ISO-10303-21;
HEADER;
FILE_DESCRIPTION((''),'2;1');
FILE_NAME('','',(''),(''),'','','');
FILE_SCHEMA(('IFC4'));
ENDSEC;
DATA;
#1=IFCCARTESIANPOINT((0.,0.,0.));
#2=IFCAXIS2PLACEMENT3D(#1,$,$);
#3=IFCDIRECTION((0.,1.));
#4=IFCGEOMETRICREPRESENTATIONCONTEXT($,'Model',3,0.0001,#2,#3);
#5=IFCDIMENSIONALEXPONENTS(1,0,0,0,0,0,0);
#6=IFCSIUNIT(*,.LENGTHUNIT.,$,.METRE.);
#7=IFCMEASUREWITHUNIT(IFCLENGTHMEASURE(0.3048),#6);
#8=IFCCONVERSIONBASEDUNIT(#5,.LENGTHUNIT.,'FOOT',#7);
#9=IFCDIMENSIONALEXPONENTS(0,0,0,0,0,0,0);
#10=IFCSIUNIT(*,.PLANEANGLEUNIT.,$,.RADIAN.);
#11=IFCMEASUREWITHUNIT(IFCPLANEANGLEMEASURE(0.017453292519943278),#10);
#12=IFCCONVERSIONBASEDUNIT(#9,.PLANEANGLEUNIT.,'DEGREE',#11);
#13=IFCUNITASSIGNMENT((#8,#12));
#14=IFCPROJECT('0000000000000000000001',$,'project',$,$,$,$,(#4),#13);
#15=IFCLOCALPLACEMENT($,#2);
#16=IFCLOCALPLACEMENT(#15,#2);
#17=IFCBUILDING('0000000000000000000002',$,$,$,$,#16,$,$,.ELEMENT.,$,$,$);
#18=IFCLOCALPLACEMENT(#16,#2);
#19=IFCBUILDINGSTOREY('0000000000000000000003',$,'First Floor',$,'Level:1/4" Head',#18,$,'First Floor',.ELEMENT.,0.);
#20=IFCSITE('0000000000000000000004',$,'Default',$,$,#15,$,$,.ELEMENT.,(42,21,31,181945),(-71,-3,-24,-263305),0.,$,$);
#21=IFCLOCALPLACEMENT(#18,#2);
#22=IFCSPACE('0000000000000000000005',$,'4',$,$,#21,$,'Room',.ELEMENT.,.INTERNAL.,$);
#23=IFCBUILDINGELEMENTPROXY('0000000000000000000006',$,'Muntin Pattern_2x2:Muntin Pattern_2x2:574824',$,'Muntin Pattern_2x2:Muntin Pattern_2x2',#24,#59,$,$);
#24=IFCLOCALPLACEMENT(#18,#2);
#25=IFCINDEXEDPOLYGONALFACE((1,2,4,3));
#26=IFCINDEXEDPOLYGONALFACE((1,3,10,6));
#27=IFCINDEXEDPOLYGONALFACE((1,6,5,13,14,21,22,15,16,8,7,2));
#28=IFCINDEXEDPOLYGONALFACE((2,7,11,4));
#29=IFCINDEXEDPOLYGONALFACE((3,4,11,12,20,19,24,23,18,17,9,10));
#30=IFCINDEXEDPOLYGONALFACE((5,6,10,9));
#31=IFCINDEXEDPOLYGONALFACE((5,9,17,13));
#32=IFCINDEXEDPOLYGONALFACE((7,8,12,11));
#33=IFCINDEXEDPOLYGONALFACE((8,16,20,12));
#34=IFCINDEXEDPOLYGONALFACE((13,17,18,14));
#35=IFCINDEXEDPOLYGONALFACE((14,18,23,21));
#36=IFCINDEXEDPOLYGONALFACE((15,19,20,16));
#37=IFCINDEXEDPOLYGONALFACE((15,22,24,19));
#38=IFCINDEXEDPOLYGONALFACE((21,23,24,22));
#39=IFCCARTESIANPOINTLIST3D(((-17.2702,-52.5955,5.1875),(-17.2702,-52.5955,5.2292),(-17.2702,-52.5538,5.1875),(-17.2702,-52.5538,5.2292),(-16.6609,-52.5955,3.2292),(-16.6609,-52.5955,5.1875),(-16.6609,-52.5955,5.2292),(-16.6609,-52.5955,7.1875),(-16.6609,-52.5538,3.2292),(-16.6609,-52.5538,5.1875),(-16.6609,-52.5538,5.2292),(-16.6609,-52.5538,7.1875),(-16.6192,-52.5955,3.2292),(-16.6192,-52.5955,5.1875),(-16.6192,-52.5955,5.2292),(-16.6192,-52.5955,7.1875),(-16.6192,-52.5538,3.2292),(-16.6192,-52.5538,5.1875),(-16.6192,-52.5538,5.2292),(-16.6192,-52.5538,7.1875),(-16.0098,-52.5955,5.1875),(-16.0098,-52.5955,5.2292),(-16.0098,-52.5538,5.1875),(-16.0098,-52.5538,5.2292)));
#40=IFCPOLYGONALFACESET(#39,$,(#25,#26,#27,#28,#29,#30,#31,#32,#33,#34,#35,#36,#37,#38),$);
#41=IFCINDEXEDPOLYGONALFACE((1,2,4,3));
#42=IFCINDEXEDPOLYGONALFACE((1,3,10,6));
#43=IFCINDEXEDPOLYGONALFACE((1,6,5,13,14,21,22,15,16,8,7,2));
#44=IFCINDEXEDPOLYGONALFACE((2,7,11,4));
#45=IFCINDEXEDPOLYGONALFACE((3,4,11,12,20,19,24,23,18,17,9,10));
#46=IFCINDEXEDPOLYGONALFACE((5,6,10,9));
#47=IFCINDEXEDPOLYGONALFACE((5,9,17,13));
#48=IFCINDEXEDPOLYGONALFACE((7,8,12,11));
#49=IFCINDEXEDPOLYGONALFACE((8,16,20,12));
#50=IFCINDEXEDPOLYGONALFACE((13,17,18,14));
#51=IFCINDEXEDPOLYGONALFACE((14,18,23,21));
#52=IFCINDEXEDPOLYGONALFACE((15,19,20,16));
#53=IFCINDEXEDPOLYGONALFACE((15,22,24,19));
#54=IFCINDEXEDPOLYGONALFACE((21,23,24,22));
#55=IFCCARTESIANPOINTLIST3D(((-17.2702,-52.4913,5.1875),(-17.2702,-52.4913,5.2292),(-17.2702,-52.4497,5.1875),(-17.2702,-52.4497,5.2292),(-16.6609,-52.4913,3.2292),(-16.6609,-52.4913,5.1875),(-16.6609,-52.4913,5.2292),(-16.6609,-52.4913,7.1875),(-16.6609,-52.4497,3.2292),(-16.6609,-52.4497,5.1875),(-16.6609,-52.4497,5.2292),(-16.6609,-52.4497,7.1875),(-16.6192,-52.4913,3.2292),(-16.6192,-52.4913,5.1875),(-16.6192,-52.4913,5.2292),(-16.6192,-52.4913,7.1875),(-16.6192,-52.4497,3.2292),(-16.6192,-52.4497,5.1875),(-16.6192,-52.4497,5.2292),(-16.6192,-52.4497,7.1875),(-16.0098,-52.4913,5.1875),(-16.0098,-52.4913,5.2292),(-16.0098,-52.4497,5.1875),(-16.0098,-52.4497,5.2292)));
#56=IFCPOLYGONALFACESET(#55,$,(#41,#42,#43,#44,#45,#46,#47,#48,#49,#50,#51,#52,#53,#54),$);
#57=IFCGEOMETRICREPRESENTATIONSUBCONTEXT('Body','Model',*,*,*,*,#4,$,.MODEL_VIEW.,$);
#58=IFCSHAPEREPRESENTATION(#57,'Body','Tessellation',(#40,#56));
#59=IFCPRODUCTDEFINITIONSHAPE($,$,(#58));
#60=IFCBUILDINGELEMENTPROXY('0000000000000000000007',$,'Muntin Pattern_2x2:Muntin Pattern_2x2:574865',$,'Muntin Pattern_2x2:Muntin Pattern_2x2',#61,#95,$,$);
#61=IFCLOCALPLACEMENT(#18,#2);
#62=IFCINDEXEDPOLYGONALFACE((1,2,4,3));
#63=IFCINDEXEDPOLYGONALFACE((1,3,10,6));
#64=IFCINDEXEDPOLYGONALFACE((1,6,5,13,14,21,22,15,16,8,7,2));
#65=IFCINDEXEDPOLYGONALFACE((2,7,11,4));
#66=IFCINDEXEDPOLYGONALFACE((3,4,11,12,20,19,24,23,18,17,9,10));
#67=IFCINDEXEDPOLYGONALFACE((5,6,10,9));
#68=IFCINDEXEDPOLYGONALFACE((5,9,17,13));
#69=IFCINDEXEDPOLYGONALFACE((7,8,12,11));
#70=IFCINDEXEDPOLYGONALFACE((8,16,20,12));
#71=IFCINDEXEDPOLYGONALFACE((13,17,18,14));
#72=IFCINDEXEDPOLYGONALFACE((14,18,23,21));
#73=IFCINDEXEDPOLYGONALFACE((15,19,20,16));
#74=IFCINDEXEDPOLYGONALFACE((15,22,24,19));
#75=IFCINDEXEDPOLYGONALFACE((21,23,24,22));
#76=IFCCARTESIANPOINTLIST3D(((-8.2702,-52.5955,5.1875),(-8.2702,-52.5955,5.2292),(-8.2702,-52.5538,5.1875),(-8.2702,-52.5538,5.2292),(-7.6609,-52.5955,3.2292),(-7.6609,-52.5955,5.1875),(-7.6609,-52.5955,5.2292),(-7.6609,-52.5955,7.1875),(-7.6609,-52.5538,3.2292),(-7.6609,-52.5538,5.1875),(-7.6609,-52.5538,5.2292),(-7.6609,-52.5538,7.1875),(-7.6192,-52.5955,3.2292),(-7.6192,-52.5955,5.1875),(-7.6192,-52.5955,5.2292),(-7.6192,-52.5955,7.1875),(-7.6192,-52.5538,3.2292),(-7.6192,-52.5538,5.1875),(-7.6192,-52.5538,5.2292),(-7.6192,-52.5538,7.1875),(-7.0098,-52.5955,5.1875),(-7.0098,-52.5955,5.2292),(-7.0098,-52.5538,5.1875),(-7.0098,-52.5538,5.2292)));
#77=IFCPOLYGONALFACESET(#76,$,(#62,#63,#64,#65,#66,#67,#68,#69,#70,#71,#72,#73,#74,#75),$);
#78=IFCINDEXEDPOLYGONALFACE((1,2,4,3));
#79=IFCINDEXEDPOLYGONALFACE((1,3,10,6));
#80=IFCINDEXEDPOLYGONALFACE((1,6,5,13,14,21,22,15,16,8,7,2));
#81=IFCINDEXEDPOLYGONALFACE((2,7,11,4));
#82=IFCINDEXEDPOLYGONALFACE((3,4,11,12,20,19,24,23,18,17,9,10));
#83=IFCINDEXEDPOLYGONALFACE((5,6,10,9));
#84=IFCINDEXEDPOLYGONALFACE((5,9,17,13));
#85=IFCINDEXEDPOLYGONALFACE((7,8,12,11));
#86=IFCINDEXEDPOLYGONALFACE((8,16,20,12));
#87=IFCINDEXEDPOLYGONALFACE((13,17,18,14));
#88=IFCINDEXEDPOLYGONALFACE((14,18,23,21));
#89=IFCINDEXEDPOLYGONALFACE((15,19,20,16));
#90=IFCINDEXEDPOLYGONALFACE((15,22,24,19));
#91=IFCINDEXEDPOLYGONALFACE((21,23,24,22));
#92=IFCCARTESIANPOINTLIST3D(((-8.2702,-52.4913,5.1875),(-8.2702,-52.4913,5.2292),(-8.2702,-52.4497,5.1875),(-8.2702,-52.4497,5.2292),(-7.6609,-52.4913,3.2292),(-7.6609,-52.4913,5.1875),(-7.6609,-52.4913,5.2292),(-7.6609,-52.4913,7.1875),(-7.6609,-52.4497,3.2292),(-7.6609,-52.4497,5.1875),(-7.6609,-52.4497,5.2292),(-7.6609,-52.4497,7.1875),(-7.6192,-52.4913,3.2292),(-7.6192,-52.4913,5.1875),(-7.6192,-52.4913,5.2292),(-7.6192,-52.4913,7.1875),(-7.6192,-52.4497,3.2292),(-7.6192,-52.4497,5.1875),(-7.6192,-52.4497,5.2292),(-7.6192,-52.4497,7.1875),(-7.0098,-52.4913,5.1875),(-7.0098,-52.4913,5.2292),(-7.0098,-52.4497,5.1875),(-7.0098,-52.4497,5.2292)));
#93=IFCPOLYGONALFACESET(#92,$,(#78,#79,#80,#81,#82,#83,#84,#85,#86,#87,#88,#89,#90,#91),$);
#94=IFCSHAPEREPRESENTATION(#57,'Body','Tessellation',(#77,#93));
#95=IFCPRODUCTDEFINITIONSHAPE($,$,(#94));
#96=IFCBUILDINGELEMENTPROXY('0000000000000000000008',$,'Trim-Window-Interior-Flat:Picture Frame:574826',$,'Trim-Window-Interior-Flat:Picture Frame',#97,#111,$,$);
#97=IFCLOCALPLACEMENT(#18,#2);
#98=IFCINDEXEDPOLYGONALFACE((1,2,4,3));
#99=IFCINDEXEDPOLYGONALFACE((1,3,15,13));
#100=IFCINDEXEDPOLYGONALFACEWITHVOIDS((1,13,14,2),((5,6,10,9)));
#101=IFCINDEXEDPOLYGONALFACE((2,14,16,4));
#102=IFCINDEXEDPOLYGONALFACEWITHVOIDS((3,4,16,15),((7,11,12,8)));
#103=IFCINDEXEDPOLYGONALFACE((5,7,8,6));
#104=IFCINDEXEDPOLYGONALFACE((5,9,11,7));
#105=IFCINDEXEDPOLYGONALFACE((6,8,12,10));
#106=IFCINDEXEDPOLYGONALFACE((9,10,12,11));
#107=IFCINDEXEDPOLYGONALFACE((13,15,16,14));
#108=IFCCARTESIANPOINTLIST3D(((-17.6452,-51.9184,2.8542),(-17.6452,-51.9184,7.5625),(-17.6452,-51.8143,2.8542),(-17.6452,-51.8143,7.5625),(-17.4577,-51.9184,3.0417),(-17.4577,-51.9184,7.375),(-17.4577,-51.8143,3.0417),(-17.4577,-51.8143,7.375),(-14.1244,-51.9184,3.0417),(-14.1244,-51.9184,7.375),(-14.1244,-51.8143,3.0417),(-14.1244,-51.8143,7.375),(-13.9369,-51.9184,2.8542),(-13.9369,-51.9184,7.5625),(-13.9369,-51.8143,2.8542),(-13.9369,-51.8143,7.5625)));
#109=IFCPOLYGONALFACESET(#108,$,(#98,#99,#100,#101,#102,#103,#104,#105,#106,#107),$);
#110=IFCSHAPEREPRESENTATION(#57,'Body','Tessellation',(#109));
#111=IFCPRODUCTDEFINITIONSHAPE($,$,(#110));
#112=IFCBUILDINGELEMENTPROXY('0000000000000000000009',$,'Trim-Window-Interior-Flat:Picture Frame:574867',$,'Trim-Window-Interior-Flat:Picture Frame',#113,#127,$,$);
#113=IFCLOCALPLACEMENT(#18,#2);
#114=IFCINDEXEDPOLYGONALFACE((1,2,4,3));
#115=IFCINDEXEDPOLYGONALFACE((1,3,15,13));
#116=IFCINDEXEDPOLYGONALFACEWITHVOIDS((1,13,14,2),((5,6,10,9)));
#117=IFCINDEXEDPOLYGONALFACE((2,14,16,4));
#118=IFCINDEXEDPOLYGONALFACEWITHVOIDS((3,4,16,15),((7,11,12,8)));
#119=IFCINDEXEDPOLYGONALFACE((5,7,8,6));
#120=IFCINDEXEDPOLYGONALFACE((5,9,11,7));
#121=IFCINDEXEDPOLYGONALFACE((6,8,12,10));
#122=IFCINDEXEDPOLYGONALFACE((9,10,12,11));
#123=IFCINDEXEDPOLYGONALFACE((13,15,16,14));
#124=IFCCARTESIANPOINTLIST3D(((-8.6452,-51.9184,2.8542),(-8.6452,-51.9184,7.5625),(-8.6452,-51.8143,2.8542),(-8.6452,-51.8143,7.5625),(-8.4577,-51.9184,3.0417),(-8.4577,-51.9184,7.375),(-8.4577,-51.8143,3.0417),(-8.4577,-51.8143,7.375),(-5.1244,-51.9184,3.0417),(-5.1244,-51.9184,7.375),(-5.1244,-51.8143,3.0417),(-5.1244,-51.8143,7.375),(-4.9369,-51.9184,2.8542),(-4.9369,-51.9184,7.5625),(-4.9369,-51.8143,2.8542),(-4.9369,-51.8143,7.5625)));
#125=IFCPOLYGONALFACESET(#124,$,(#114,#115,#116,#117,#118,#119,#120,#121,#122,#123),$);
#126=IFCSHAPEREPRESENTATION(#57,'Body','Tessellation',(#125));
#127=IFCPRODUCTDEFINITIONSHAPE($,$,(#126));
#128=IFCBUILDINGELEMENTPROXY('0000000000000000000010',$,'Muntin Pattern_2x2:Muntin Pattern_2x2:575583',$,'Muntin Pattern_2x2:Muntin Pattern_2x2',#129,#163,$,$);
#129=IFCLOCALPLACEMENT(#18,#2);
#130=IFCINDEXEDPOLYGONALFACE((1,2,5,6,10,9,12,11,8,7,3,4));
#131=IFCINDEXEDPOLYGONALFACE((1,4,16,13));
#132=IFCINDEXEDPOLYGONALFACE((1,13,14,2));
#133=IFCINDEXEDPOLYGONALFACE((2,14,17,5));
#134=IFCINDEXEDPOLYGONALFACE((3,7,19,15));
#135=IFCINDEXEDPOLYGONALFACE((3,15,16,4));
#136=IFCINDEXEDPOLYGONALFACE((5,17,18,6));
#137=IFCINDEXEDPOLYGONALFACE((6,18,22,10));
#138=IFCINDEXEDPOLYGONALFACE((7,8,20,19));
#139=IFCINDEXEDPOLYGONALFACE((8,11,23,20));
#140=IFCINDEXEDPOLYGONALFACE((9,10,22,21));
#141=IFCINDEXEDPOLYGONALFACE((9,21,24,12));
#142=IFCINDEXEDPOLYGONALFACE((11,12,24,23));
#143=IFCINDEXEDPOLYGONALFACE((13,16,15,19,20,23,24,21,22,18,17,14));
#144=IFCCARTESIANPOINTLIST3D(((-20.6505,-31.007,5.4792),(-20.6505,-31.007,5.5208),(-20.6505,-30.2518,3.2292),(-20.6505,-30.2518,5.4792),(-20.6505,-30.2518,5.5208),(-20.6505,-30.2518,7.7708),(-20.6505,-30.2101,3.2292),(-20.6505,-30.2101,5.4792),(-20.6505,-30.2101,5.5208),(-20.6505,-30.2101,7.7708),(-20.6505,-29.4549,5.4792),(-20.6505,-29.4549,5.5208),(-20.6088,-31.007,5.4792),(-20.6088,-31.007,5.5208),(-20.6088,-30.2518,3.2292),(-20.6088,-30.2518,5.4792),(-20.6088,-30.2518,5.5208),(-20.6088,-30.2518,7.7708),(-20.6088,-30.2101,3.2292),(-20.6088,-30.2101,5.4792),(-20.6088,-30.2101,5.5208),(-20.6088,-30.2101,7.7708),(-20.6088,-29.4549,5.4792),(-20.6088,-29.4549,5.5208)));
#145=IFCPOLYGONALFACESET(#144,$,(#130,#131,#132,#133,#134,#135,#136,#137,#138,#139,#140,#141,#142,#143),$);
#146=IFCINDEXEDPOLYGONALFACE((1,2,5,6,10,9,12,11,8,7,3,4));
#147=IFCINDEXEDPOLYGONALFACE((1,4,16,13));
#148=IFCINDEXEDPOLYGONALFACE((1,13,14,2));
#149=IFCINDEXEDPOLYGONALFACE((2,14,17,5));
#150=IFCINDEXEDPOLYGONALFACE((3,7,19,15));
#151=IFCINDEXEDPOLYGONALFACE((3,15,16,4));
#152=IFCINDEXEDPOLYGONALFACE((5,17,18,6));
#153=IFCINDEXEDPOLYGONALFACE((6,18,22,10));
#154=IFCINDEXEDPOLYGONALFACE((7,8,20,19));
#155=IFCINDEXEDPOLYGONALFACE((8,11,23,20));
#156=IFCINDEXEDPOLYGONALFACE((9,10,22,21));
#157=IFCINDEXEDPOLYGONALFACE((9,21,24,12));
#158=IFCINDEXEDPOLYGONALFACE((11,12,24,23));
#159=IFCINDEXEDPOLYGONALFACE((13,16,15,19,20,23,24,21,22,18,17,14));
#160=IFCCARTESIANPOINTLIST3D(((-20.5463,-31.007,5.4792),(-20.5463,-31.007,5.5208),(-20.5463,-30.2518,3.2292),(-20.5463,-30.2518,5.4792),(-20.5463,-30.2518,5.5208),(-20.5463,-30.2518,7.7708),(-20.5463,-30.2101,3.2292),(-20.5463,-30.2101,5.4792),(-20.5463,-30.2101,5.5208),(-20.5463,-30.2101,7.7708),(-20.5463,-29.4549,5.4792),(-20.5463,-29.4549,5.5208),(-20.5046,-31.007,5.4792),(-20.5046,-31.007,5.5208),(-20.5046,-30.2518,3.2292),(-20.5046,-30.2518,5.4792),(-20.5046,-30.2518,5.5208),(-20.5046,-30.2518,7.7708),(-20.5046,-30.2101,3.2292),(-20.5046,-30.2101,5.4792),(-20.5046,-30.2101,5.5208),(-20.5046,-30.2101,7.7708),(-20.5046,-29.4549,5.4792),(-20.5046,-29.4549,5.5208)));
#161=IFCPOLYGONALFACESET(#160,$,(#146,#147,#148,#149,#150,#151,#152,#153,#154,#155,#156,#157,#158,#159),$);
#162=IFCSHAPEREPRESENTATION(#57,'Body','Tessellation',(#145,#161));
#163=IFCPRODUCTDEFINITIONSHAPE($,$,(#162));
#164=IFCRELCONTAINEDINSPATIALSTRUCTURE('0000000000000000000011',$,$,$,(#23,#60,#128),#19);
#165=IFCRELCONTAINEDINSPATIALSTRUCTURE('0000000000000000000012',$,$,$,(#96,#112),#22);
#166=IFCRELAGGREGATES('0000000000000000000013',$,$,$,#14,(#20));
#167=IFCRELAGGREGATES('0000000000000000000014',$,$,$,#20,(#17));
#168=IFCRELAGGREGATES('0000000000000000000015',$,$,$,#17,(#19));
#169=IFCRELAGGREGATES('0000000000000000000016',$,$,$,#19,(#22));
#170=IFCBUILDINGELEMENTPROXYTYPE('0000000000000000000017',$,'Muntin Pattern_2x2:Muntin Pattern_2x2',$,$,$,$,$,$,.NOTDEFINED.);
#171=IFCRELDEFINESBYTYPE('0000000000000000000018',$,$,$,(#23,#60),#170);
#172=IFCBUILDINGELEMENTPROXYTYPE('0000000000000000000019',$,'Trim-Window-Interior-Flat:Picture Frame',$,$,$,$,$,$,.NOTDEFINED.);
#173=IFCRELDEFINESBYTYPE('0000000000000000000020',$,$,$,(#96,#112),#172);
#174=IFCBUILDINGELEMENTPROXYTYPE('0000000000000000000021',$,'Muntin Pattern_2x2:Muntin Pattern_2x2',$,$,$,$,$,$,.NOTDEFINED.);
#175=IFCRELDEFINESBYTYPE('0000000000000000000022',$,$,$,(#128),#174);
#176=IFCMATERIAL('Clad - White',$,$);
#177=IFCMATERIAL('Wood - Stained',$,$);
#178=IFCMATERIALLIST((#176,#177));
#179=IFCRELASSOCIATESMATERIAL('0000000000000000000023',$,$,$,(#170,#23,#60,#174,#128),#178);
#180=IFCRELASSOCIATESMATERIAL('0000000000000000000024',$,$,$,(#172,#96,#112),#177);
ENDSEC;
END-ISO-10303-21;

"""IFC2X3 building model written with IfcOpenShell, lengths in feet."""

from ifc_helpers import new_model, entity, si_unit, converted_unit, direction, frame, origin, place, context, subcontext, project, spatial, polyline, outline, extrude, source, transform, mapped, material, material_list, type_object, type_shapes, element, save


model = new_model("IFC2X3")

# Units and contexts
model_context = context("Model", 3, precision=0.0001, world=origin(), true_north=direction((0.0, 1.0)))
body_context = subcontext(model_context, "Body", "Model", "MODEL_VIEW")
ifc_project = project(units=[converted_unit("LENGTHUNIT", "FOOT", entity("IfcLengthMeasure", 0.3048), si_unit("LENGTHUNIT", "METRE"), dimensions=[1, 0, 0, 0, 0, 0, 0]), converted_unit("PLANEANGLEUNIT", "DEGREE", entity("IfcPlaneAngleMeasure", 0.017453292519943278), si_unit("PLANEANGLEUNIT", "RADIAN"), dimensions=[0, 0, 0, 0, 0, 0, 0])], contexts=[model_context])

# Site, building, storey
site_placement = place(None, origin())
site = spatial("IfcSite", under=ifc_project, at=site_placement, Name="Default", CompositionType="ELEMENT", RefLatitude=(42, 21, 31, 181945), RefLongitude=(-71, -3, -24, -263305), RefElevation=0.0)
building_placement = place(site_placement, origin())
building = spatial("IfcBuilding", under=site, at=building_placement, CompositionType="ELEMENT")
storey_placement = place(building_placement, origin())
storey = spatial("IfcBuildingStorey", under=building, at=storey_placement, Name="First Floor", ObjectType="Level:1/4\" Head", LongName="First Floor", CompositionType="ELEMENT", Elevation=0.0)

# Shared definitions
space_1_placement = place(storey_placement, origin())
space_1 = spatial("IfcSpace", under=storey, at=space_1_placement, Name="4", LongName="Room", CompositionType="ELEMENT", InteriorOrExteriorSpace="INTERNAL")

# Building element proxies
ifc_material_1 = material(Name="Clad - White")
ifc_material_2 = material(Name="Wood - Stained")
ifc_material_list_1 = material_list([ifc_material_1, ifc_material_2])
building_element_proxy_type_1 = type_object("IfcBuildingElementProxyType", Name="Muntin Pattern_2x2:Muntin Pattern_2x2", PredefinedType="NOTDEFINED", material=ifc_material_list_1)
shared_shape_1 = source(origin(), body_context, "Body", "SweptSolid", [
    extrude(outline(polyline([(0.0208, -0.0208), (1.9792, -0.0208), (1.9792, 0.0208), (0.0208, 0.0208), (0.0208, 0.6302), (-0.0208, 0.6302), (-0.0208, 0.0208), (-1.9792, 0.0208), (-1.9792, -0.0208), (-0.0208, -0.0208), (-0.0208, -0.6302), (0.0208, -0.6302), (0.0208, -0.0208)])), frame((0.0, -0.0729, 1.9792), z_axis=(0.0, 1.0, 0.0), x_axis=(0.0, 0.0, 1.0)), (0.0, 0.0, 1.0), 0.0417),
    extrude(outline(polyline([(0.0208, -0.0208), (1.9792, -0.0208), (1.9792, 0.0208), (0.0208, 0.0208), (0.0208, 0.6302), (-0.0208, 0.6302), (-0.0208, 0.0208), (-1.9792, 0.0208), (-1.9792, -0.0208), (-0.0208, -0.0208), (-0.0208, -0.6302), (0.0208, -0.6302), (0.0208, -0.0208)])), frame((0.0, 0.0313, 1.9792), z_axis=(0.0, 1.0, 0.0), x_axis=(0.0, 0.0, 1.0)), (0.0, 0.0, 1.0), 0.0417),
])
type_shapes(building_element_proxy_type_1, [shared_shape_1])
for number, where, name in (
    (1, (-16.64, -52.5226, 3.2292), "Muntin Pattern_2x2:Muntin Pattern_2x2:574824"),
    (2, (-7.64, -52.5226, 3.2292), "Muntin Pattern_2x2:Muntin Pattern_2x2:574865"),
):
    element("IfcBuildingElementProxy", number, at=place(storey_placement, frame(where)), inside=storey, type_object=building_element_proxy_type_1, material=ifc_material_list_1, Name=name, ObjectType="Muntin Pattern_2x2:Muntin Pattern_2x2", context=body_context, shape_type="MappedRepresentation", body=[
        mapped(shared_shape_1, transform((0.0, 0.0, 0.0), scale=1.0)),
    ])
building_element_proxy_type_2 = type_object("IfcBuildingElementProxyType", Name="Trim-Window-Interior-Flat:Picture Frame", PredefinedType="NOTDEFINED", material=ifc_material_2)
shared_shape_2 = source(origin(), body_context, "Body", "SweptSolid", [
    extrude(outline(polyline([(-1.8542, -2.3542), (1.8542, -2.3542), (1.8542, 2.3542), (-1.8542, 2.3542), (-1.8542, -2.3542)]), holes=[polyline([(-1.6667, -2.1667), (-1.6667, 2.1667), (1.6667, 2.1667), (1.6667, -2.1667), (-1.6667, -2.1667)])]), frame((0.0, -2.2083, 0.0), z_axis=(0.0, 0.0, 1.0), x_axis=(-1.0, 0.0, 0.0)), (0.0, 0.0, 1.0), 0.1042),
])
type_shapes(building_element_proxy_type_2, [shared_shape_2])
for number, where, z_axis, x_axis, name in (
    (3, (-15.7911, -51.9184, 7.4167), (0.0, 1.0, 0.0), (-1.0, 0.0, 0.0), "Trim-Window-Interior-Flat:Picture Frame:574826"),
    (4, (-6.7911, -51.9184, 7.4167), (0.0, 1.0, 0.0), (-1.0, 0.0, 0.0), "Trim-Window-Interior-Flat:Picture Frame:574867"),
):
    element("IfcBuildingElementProxy", number, at=place(space_1_placement, frame(where, z_axis=z_axis, x_axis=x_axis)), inside=space_1, type_object=building_element_proxy_type_2, material=ifc_material_2, Name=name, ObjectType="Trim-Window-Interior-Flat:Picture Frame", context=body_context, shape_type="MappedRepresentation", body=[
        mapped(shared_shape_2, transform((0.0, 0.0, 0.0), scale=1.0)),
    ])
building_element_proxy_type_3 = type_object("IfcBuildingElementProxyType", Name="Muntin Pattern_2x2:Muntin Pattern_2x2", PredefinedType="NOTDEFINED", material=ifc_material_list_1)
shared_shape_3 = source(origin(), body_context, "Body", "SweptSolid", [
    extrude(outline(polyline([(0.0208, -0.0208), (2.2708, -0.0208), (2.2708, 0.0208), (0.0208, 0.0208), (0.0208, 0.776), (-0.0208, 0.776), (-0.0208, 0.0208), (-2.2708, 0.0208), (-2.2708, -0.0208), (-0.0208, -0.0208), (-0.0208, -0.776), (0.0208, -0.776), (0.0208, -0.0208)])), frame((0.0, 0.0313, 2.2708), z_axis=(0.0, 1.0, 0.0), x_axis=(0.0, 0.0, 1.0)), (0.0, 0.0, 1.0), 0.0417),
    extrude(outline(polyline([(0.0208, -0.0208), (2.2708, -0.0208), (2.2708, 0.0208), (0.0208, 0.0208), (0.0208, 0.776), (-0.0208, 0.776), (-0.0208, 0.0208), (-2.2708, 0.0208), (-2.2708, -0.0208), (-0.0208, -0.0208), (-0.0208, -0.776), (0.0208, -0.776), (0.0208, -0.0208)])), frame((0.0, -0.0729, 2.2708), z_axis=(0.0, 1.0, 0.0), x_axis=(0.0, 0.0, 1.0)), (0.0, 0.0, 1.0), 0.0417),
])
type_shapes(building_element_proxy_type_3, [shared_shape_3])
for number, where, z_axis, x_axis, name in (
    (5, (-20.5775, -30.2309, 3.2292), (0.0, 0.0, 1.0), (0.0, 1.0, 0.0), "Muntin Pattern_2x2:Muntin Pattern_2x2:575583"),
):
    element("IfcBuildingElementProxy", number, at=place(storey_placement, frame(where, z_axis=z_axis, x_axis=x_axis)), inside=storey, type_object=building_element_proxy_type_3, material=ifc_material_list_1, Name=name, ObjectType="Muntin Pattern_2x2:Muntin Pattern_2x2", context=body_context, shape_type="MappedRepresentation", body=[
        mapped(shared_shape_3, transform((0.0, 0.0, 0.0), scale=1.0)),
    ])

save(model, "model.ifc")
